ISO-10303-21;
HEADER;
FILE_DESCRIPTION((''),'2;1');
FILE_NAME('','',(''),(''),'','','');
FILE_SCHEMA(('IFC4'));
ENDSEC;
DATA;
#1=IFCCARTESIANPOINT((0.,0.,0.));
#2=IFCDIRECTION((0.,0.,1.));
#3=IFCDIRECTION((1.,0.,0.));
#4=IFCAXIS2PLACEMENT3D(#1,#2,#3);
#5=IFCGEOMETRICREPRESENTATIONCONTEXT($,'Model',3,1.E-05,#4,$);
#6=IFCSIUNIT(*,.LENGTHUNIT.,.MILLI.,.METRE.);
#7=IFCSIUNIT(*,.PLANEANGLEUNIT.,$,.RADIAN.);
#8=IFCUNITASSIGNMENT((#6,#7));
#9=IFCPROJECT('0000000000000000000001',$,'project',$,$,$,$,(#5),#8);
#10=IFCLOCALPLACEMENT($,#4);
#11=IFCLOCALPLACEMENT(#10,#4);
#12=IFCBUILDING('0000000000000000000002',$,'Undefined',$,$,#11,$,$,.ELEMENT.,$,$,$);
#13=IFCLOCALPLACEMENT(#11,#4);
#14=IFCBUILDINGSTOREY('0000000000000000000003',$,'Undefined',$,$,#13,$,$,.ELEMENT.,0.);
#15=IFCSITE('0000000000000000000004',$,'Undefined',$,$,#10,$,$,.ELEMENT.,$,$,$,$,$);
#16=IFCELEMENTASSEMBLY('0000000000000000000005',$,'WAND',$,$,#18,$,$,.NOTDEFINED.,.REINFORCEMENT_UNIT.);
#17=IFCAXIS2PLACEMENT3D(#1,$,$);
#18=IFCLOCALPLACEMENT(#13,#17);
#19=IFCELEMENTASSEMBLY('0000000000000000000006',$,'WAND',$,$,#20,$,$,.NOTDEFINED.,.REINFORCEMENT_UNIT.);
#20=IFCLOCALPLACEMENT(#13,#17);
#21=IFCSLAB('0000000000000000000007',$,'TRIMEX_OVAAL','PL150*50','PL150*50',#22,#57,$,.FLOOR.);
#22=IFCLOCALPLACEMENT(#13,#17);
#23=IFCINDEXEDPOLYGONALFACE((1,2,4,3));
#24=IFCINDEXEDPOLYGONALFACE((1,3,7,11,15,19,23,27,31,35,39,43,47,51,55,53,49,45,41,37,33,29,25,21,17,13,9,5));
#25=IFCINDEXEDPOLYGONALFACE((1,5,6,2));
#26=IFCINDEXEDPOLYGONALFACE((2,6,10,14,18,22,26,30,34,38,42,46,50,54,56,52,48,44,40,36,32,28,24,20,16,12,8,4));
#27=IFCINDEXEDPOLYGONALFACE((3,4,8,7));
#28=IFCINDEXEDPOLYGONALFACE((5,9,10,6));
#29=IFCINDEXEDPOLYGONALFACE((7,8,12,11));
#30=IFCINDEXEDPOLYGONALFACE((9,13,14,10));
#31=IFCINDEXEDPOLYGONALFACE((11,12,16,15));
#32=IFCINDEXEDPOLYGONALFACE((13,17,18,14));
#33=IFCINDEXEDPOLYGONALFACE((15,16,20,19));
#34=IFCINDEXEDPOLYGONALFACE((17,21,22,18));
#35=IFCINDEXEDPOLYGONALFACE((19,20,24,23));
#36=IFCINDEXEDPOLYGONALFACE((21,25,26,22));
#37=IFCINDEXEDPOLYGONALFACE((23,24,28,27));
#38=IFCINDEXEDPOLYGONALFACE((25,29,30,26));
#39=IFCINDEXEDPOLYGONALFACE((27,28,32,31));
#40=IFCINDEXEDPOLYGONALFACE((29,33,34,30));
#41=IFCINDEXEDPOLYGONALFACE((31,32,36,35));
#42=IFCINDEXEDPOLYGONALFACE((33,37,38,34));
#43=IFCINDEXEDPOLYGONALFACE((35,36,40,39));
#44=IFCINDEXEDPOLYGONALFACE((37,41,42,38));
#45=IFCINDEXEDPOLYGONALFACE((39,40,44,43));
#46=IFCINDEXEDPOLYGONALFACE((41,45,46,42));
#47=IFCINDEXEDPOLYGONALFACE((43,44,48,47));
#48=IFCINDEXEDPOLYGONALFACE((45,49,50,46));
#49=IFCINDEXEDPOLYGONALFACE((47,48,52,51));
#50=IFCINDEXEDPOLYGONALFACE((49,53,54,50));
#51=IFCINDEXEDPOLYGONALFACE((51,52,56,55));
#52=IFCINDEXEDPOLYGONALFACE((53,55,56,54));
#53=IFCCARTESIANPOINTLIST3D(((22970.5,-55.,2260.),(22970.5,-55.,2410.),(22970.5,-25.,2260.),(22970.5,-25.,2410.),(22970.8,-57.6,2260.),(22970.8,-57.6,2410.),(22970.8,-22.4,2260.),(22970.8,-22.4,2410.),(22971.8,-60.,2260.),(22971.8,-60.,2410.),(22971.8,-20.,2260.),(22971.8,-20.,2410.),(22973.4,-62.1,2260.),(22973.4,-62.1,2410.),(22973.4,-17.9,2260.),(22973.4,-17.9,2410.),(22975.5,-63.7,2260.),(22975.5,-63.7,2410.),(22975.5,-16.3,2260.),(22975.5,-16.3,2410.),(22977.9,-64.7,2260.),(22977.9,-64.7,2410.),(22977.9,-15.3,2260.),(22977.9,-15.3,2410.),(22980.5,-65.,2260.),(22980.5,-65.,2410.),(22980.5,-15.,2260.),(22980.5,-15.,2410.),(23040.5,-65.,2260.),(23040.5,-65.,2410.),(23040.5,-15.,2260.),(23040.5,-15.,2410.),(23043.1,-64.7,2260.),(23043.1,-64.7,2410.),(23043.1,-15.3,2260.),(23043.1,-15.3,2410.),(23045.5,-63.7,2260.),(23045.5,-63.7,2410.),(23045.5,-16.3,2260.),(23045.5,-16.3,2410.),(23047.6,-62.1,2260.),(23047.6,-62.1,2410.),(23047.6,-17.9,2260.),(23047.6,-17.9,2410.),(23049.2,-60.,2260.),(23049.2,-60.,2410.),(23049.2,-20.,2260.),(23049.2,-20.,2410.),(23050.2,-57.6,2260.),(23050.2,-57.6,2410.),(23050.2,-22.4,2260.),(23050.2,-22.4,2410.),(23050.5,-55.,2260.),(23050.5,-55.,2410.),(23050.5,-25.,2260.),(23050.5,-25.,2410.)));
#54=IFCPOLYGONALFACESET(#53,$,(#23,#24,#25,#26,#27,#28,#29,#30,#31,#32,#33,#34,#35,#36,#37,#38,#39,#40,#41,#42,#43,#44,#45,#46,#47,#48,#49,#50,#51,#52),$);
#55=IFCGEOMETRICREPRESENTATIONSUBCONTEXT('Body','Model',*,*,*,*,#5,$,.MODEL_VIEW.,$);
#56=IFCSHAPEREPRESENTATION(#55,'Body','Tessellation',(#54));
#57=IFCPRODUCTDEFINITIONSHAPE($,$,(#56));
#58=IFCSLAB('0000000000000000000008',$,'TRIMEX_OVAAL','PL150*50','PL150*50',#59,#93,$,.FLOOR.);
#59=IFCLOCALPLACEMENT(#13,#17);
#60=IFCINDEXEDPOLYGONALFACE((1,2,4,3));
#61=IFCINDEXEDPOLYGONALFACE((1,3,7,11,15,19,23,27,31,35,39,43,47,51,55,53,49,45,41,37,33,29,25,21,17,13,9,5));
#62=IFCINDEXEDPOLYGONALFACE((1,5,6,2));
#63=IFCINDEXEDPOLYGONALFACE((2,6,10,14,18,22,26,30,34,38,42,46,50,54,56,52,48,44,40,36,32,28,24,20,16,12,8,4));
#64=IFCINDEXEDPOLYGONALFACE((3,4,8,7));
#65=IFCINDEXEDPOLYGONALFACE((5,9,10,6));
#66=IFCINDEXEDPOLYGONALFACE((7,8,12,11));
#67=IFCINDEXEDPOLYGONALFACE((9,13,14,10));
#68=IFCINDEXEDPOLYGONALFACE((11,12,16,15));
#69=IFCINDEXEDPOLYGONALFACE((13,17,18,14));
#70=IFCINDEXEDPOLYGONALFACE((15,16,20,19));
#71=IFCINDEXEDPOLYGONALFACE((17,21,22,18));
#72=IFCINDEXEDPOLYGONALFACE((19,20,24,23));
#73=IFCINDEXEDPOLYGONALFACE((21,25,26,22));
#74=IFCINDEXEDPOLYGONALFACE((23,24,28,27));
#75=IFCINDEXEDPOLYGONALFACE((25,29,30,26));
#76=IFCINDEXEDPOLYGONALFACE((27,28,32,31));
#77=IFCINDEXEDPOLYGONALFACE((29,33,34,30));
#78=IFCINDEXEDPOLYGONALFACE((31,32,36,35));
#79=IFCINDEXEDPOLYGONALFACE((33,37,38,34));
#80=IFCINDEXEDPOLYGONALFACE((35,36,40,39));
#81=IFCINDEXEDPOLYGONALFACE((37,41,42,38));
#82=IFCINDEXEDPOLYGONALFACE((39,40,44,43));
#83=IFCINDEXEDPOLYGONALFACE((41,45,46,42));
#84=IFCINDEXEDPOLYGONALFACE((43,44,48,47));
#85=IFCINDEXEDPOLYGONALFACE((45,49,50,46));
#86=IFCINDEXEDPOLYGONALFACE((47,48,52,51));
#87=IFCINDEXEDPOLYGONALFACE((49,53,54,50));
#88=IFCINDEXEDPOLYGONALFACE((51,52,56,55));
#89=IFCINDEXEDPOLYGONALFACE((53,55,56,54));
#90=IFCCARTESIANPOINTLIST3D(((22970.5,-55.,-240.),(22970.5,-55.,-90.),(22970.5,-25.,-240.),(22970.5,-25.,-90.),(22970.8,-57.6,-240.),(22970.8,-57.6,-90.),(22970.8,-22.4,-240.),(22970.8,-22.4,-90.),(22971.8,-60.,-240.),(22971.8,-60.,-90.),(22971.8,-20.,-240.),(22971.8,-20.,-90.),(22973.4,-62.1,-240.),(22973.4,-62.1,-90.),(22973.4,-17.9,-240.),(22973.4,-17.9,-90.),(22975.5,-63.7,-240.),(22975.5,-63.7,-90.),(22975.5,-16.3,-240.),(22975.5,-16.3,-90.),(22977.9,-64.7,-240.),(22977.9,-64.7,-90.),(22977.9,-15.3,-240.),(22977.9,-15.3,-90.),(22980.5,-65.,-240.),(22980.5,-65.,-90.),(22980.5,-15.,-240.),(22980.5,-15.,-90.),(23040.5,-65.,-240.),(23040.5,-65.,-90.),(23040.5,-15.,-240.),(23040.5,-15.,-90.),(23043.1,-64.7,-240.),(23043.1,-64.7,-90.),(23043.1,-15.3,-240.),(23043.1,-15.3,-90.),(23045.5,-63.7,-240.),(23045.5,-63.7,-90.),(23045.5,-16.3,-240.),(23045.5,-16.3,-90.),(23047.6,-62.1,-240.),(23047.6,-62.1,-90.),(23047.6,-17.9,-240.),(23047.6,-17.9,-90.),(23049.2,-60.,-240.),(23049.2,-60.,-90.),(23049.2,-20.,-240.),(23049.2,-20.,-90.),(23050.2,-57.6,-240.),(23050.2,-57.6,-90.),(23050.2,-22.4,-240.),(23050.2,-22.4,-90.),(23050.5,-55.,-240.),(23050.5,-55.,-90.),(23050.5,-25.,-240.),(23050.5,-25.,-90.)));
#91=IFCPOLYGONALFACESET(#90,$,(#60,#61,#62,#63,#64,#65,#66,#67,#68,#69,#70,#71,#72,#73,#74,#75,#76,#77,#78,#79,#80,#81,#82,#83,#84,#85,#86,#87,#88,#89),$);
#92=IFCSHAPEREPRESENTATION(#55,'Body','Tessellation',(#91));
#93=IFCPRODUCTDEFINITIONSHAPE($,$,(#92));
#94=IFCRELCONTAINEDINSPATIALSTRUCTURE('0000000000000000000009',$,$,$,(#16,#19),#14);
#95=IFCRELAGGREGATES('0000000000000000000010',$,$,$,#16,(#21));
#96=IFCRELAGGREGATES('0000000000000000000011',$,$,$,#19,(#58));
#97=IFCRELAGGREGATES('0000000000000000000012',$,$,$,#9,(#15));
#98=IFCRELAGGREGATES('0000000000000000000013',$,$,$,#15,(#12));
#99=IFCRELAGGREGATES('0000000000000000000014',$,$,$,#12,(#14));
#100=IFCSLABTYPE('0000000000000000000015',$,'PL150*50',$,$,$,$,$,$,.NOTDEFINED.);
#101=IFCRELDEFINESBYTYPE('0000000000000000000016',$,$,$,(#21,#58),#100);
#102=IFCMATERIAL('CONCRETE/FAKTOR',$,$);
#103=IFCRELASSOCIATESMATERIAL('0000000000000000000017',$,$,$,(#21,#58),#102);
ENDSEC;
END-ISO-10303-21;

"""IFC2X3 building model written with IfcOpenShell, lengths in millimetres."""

from ifc_helpers import new_model, si_unit, frame, frame_2d, origin_with_axes, place, context, subcontext, project, spatial, polyline, circle_curve, parameter, trimmed, segment, composite_curve, outline, extrude, material, type_object, element, aggregate, save


model = new_model("IFC2X3")

# Units and contexts
model_context = context("Model", 3, precision=1e-05, world=origin_with_axes())
body_context = subcontext(model_context, "Body", "Model", "MODEL_VIEW")
ifc_project = project(units=[si_unit("LENGTHUNIT", "METRE", prefix="MILLI"), si_unit("PLANEANGLEUNIT", "RADIAN")], contexts=[model_context])

# Site, building, storey
site_placement = place(None, origin_with_axes())
site = spatial("IfcSite", under=ifc_project, at=site_placement, Name="Undefined", CompositionType="ELEMENT")
building_placement = place(site_placement, origin_with_axes())
building = spatial("IfcBuilding", under=site, at=building_placement, Name="Undefined", CompositionType="ELEMENT")
storey_placement = place(building_placement, origin_with_axes())
storey = spatial("IfcBuildingStorey", under=building, at=storey_placement, Name="Undefined", CompositionType="ELEMENT", Elevation=0.0)

# Shared definitions
ifc_material_1 = material(Name="CONCRETE/FAKTOR")

# Element assembly
assembly_1_placement = place(storey_placement, origin_with_axes())
assembly_1 = element("IfcElementAssembly", 1, at=assembly_1_placement, inside=storey, Name="WAND", AssemblyPlace="NOTDEFINED", PredefinedType="REINFORCEMENT_UNIT")

# Element assembly
assembly_2_placement = place(storey_placement, origin_with_axes())
assembly_2 = element("IfcElementAssembly", 2, at=assembly_2_placement, inside=storey, Name="WAND", AssemblyPlace="NOTDEFINED", PredefinedType="REINFORCEMENT_UNIT")
slab_type = type_object("IfcSlabType", Name="PL150*50", PredefinedType="NOTDEFINED")

# Slabs
slab_1_placement = place(assembly_1_placement, frame((23050.5, -65.0, 2335.0), z_axis=(0.0, 0.0, 1.0), x_axis=(0.0, 1.0, 0.0)))
slab_1 = element("IfcSlab", 3, at=slab_1_placement, type_object=slab_type, material=ifc_material_1, Name="TRIMEX_OVAAL", Description="PL150*50", ObjectType="PL150*50", PredefinedType="FLOOR", context=body_context, shape_type="SweptSolid", body=[
    extrude(outline(composite_curve([segment(trimmed(circle_curve(frame_2d((10.0, 10.0), x_axis=(-1.0, 0.0)), 10.0), [parameter(0.0)], [parameter(1.570796)], True, "PARAMETER"), True, "CONTINUOUS"), segment(polyline([(10.0, 0.0), (40.0, 0.0)]), True, "CONTINUOUS"), segment(trimmed(circle_curve(frame_2d((40.0, 10.0), x_axis=(0.0, -1.0)), 10.0), [parameter(0.0)], [parameter(1.570796)], True, "PARAMETER"), True, "CONTINUOUS"), segment(polyline([(50.0, 10.0), (50.0, 70.0)]), True, "CONTINUOUS"), segment(trimmed(circle_curve(frame_2d((40.0, 70.0), x_axis=(1.0, 0.0)), 10.0), [parameter(0.0)], [parameter(1.570796)], True, "PARAMETER"), True, "CONTINUOUS"), segment(polyline([(40.0, 80.0), (10.0, 80.0)]), True, "CONTINUOUS"), segment(trimmed(circle_curve(frame_2d((10.0, 70.0), x_axis=(0.0, 1.0)), 10.0), [parameter(0.0)], [parameter(1.570796)], True, "PARAMETER"), True, "CONTINUOUS"), segment(polyline([(0.0, 70.0), (0.0, 10.0)]), True, "CONTINUOUS")], self_intersect=True)), frame((0.0, 0.0, -75.0), z_axis=(0.0, 0.0, 1.0), x_axis=(1.0, 0.0, 0.0)), (0.0, 0.0, 1.0), 150.0),
])
aggregate(assembly_1, [slab_1])
slab_2_placement = place(assembly_2_placement, frame((22970.5, -15.0, -165.0), z_axis=(0.0, 0.0, 1.0), x_axis=(0.0, -1.0, 0.0)))
slab_2 = element("IfcSlab", 4, at=slab_2_placement, type_object=slab_type, material=ifc_material_1, Name="TRIMEX_OVAAL", Description="PL150*50", ObjectType="PL150*50", PredefinedType="FLOOR", context=body_context, shape_type="SweptSolid", body=[
    extrude(outline(composite_curve([segment(trimmed(circle_curve(frame_2d((10.0, 10.0), x_axis=(-1.0, 0.0)), 10.0), [parameter(0.0)], [parameter(1.570796)], True, "PARAMETER"), True, "CONTINUOUS"), segment(polyline([(10.0, 0.0), (40.0, 0.0)]), True, "CONTINUOUS"), segment(trimmed(circle_curve(frame_2d((40.0, 10.0), x_axis=(0.0, -1.0)), 10.0), [parameter(0.0)], [parameter(1.570796)], True, "PARAMETER"), True, "CONTINUOUS"), segment(polyline([(50.0, 10.0), (50.0, 70.0)]), True, "CONTINUOUS"), segment(trimmed(circle_curve(frame_2d((40.0, 70.0), x_axis=(1.0, 0.0)), 10.0), [parameter(0.0)], [parameter(1.570796)], True, "PARAMETER"), True, "CONTINUOUS"), segment(polyline([(40.0, 80.0), (10.0, 80.0)]), True, "CONTINUOUS"), segment(trimmed(circle_curve(frame_2d((10.0, 70.0), x_axis=(0.0, 1.0)), 10.0), [parameter(0.0)], [parameter(1.570796)], True, "PARAMETER"), True, "CONTINUOUS"), segment(polyline([(0.0, 70.0), (0.0, 10.0)]), True, "CONTINUOUS")], self_intersect=True)), frame((0.0, 0.0, -75.0), z_axis=(0.0, 0.0, 1.0), x_axis=(1.0, 0.0, 0.0)), (0.0, 0.0, 1.0), 150.0),
])
aggregate(assembly_2, [slab_2])

save(model, "model.ifc")
